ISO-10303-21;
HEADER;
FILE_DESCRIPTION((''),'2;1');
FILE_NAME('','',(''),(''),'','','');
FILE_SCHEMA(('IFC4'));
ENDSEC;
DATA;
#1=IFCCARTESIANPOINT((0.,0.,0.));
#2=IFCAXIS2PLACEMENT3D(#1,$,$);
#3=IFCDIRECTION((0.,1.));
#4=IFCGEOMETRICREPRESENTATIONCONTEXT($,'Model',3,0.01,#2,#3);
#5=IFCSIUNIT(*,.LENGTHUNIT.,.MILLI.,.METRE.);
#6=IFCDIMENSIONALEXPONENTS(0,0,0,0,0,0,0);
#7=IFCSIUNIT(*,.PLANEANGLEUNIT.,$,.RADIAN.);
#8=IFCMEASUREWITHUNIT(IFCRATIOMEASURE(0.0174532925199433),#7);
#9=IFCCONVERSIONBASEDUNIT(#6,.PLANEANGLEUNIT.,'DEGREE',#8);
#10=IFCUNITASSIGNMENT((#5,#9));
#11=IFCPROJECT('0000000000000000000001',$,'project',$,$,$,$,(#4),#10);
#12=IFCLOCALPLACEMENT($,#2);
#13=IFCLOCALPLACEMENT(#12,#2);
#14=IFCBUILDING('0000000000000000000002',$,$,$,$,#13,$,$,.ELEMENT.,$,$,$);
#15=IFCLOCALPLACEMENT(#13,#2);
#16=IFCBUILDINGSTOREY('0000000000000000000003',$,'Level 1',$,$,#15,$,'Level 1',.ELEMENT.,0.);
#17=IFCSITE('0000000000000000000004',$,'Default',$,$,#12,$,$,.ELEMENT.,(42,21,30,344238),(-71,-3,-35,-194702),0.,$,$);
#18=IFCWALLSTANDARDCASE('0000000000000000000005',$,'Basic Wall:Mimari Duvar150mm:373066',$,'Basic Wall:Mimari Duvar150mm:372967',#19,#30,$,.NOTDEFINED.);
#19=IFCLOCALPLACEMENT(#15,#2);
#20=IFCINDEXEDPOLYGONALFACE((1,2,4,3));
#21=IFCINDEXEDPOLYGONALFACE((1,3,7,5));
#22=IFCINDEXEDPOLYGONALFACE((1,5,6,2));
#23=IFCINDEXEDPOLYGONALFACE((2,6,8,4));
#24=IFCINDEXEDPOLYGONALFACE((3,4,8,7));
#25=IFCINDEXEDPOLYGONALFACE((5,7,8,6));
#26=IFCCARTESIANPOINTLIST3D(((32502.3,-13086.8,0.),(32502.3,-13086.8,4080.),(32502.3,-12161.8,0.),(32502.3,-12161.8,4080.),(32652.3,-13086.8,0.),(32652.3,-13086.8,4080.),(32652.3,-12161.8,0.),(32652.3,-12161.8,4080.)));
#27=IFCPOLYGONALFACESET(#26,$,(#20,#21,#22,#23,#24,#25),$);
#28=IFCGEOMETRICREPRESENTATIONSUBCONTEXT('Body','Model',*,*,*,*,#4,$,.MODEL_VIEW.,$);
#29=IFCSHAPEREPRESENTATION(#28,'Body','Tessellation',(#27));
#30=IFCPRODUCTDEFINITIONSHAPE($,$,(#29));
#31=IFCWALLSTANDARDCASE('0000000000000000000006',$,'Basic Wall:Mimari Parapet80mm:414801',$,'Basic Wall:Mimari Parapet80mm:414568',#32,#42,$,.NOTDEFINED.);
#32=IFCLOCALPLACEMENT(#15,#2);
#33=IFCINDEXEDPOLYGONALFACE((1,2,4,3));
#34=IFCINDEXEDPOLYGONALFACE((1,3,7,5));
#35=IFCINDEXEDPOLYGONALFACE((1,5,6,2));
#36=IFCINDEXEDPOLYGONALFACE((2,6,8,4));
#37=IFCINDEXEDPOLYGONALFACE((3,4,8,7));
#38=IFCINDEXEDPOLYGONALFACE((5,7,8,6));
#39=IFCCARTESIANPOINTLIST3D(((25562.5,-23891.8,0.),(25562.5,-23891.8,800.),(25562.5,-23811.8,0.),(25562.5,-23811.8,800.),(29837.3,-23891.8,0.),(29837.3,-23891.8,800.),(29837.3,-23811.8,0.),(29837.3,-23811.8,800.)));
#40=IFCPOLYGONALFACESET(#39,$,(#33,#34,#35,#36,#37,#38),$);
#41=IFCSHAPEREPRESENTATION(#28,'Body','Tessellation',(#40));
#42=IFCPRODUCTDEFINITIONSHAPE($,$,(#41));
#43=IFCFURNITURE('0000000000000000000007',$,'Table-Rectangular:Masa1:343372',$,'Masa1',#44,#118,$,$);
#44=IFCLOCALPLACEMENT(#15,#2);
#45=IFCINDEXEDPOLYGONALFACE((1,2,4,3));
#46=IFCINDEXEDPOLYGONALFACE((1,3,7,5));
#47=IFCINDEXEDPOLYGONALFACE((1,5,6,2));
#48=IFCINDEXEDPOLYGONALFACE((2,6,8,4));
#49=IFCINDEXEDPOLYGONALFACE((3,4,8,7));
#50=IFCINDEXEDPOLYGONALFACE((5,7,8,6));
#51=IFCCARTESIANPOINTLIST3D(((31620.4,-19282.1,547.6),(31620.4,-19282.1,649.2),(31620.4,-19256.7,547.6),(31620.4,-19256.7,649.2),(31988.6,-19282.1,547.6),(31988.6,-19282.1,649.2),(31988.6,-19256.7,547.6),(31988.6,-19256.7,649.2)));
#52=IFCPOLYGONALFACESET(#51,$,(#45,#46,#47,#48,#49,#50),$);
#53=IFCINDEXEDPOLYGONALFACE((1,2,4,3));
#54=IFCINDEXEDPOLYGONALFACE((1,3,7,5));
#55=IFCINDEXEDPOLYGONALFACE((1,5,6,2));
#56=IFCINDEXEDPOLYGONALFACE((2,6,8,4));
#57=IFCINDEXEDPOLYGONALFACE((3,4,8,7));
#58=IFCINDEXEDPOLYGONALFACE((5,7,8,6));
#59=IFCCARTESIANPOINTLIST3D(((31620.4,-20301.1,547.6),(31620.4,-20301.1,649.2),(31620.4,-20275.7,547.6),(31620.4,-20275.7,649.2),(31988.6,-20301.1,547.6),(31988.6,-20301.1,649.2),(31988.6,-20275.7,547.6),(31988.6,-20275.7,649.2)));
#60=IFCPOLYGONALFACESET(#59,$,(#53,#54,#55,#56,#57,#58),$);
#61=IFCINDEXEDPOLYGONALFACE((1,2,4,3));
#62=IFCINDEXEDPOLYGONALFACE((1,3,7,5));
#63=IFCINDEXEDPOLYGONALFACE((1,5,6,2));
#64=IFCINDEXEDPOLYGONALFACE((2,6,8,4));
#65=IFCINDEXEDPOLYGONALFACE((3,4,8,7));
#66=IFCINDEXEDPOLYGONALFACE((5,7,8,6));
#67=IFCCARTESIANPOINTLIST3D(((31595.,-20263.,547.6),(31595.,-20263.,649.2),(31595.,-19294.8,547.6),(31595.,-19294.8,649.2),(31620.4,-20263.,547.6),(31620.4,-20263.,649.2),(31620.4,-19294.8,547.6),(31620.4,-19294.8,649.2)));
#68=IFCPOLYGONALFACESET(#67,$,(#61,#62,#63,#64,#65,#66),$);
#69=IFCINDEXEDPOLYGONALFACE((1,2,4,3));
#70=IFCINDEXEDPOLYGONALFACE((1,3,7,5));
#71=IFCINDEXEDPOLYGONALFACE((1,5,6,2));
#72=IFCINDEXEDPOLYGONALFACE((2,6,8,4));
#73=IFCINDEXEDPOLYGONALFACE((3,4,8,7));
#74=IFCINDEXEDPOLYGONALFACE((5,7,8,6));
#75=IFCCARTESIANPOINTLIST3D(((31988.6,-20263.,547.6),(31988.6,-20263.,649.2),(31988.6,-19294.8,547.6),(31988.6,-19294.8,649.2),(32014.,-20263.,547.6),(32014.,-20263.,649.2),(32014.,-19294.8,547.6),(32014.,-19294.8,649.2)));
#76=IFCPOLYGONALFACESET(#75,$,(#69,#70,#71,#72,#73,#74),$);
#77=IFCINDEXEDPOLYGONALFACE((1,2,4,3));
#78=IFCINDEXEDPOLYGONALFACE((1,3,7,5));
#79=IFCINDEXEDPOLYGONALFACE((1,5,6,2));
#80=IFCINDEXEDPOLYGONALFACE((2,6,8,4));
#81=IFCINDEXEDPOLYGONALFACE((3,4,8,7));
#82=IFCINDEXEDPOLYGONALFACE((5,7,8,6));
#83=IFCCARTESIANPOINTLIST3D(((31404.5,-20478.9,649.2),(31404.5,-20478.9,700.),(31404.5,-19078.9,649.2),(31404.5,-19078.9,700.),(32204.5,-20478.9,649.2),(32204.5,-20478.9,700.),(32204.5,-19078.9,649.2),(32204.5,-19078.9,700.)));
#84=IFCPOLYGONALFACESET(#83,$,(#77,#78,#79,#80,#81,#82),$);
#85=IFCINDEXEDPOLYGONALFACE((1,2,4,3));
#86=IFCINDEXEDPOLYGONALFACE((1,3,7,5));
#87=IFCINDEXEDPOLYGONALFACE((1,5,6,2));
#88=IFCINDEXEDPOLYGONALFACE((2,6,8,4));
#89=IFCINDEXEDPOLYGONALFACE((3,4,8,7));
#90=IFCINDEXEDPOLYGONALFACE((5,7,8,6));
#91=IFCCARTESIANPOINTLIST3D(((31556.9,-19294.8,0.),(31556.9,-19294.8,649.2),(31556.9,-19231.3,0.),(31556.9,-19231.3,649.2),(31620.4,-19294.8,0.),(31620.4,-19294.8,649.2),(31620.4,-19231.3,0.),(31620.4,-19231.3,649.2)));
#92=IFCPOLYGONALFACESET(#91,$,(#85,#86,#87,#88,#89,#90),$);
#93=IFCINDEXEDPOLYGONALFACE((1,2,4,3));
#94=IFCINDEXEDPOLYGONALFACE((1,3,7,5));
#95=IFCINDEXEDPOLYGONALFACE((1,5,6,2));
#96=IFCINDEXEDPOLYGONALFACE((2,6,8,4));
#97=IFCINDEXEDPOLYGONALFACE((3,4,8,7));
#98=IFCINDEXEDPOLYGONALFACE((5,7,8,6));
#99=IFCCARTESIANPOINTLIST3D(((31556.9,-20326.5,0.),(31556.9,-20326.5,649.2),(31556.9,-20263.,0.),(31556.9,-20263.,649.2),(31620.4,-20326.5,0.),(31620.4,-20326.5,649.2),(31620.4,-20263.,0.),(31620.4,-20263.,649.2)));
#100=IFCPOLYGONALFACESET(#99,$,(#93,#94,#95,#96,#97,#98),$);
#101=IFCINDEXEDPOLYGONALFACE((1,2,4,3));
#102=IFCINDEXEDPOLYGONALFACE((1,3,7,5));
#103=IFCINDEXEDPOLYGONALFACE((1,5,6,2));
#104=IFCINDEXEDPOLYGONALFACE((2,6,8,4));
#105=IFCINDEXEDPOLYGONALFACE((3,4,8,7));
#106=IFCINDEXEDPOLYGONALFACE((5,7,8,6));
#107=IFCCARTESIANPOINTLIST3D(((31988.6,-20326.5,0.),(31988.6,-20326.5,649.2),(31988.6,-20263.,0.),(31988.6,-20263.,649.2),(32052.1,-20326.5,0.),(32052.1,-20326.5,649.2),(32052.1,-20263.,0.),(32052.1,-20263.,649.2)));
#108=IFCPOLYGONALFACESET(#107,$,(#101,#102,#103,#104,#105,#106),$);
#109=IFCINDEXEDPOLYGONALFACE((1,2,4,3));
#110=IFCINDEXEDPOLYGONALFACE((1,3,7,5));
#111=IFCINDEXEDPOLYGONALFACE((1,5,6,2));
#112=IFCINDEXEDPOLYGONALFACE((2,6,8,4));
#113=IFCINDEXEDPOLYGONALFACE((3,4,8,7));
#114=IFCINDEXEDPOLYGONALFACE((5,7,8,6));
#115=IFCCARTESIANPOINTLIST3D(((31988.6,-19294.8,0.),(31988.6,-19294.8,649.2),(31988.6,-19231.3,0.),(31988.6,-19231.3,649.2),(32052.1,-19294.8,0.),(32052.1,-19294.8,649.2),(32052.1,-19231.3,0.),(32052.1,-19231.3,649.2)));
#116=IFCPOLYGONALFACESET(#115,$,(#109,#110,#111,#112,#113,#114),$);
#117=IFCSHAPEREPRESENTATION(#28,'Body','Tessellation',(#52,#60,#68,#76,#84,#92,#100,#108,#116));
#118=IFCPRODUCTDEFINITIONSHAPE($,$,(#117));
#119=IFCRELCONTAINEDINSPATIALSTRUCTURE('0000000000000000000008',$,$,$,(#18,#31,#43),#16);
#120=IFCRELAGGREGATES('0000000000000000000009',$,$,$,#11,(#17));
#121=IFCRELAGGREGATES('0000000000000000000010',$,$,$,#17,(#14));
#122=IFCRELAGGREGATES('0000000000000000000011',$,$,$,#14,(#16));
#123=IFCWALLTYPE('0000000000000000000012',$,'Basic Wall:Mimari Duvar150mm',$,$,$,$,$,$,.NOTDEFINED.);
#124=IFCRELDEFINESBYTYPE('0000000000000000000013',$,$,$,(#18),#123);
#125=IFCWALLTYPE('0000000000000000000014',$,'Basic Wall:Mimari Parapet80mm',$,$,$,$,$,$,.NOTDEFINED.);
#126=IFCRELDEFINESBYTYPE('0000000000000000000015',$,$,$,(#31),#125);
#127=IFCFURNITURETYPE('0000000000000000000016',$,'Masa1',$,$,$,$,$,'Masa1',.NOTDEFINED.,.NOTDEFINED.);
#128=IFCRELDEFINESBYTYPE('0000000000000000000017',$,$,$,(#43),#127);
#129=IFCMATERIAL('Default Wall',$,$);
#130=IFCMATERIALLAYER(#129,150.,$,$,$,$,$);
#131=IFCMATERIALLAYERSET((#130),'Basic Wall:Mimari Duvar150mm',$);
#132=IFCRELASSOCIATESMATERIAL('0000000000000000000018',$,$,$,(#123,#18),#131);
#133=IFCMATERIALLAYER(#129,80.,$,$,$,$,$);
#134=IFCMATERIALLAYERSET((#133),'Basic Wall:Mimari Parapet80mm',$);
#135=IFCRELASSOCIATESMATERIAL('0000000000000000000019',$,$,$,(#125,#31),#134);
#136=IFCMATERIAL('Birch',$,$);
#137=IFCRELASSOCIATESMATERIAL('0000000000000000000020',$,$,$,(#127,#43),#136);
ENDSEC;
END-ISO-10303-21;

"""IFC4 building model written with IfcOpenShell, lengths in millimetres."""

from ifc_helpers import new_model, entity, si_unit, converted_unit, direction, frame, frame_2d, origin, origin_2d_with_axis, place, context, subcontext, project, spatial, rectangle, extrude, source, transform, mapped, material, layer, layer_set, layer_usage, type_object, type_shapes, element, save


model = new_model("IFC4")

# Units and contexts
model_context = context("Model", 3, precision=0.01, world=origin(), true_north=direction((0.0, 1.0)))
body_context = subcontext(model_context, "Body", "Model", "MODEL_VIEW")
ifc_project = project(units=[si_unit("LENGTHUNIT", "METRE", prefix="MILLI"), converted_unit("PLANEANGLEUNIT", "DEGREE", entity("IfcRatioMeasure", 0.0174532925199433), si_unit("PLANEANGLEUNIT", "RADIAN"), dimensions=[0, 0, 0, 0, 0, 0, 0])], contexts=[model_context])

# Site, building, storey
site_placement = place(None, origin())
site = spatial("IfcSite", under=ifc_project, at=site_placement, Name="Default", CompositionType="ELEMENT", RefLatitude=(42, 21, 30, 344238), RefLongitude=(-71, -3, -35, -194702), RefElevation=0.0)
building_placement = place(site_placement, origin())
building = spatial("IfcBuilding", under=site, at=building_placement, CompositionType="ELEMENT")
storey_placement = place(building_placement, origin())
storey = spatial("IfcBuildingStorey", under=building, at=storey_placement, Name="Level 1", LongName="Level 1", CompositionType="ELEMENT", Elevation=0.0)

# Walls
ifc_material_1 = material(Name="Default Wall")
ifc_layer_1 = layer(ifc_material_1, 150.0)
ifc_layer_set_1 = layer_set([ifc_layer_1], Name="Basic Wall:Mimari Duvar150mm")
ifc_layer_usage_1 = layer_usage(ifc_layer_set_1, "AXIS2", "NEGATIVE", 75.0)
wall_type_1 = type_object("IfcWallType", Name="Basic Wall:Mimari Duvar150mm", PredefinedType="NOTDEFINED", material=ifc_layer_set_1)
wall_1_placement = place(storey_placement, frame((32577.3, -13086.8, 0.0), z_axis=(0.0, 0.0, 1.0), x_axis=(0.0, 1.0, 0.0)))
element("IfcWallStandardCase", 1, at=wall_1_placement, inside=storey, type_object=wall_type_1, material=ifc_layer_usage_1, Name="Basic Wall:Mimari Duvar150mm:373066", ObjectType="Basic Wall:Mimari Duvar150mm:372967", PredefinedType="NOTDEFINED", context=body_context, shape_type="SweptSolid", body=[
    extrude(rectangle(XDim=925.0, YDim=150.0, at=frame_2d((462.5, 0.0), x_axis=(-1.0, 0.0))), origin(), (0.0, 0.0, 1.0), 4080.0),
])
ifc_layer_2 = layer(ifc_material_1, 80.0)
ifc_layer_set_2 = layer_set([ifc_layer_2], Name="Basic Wall:Mimari Parapet80mm")
ifc_layer_usage_2 = layer_usage(ifc_layer_set_2, "AXIS2", "NEGATIVE", 40.0)
wall_type_2 = type_object("IfcWallType", Name="Basic Wall:Mimari Parapet80mm", PredefinedType="NOTDEFINED", material=ifc_layer_set_2)
wall_2_placement = place(storey_placement, frame((25562.5, -23851.8, 0.0)))
element("IfcWallStandardCase", 2, at=wall_2_placement, inside=storey, type_object=wall_type_2, material=ifc_layer_usage_2, Name="Basic Wall:Mimari Parapet80mm:414801", ObjectType="Basic Wall:Mimari Parapet80mm:414568", PredefinedType="NOTDEFINED", context=body_context, shape_type="SweptSolid", body=[
    extrude(rectangle(XDim=4274.8, YDim=80.0, at=frame_2d((2137.4, 0.0), x_axis=(-1.0, 0.0))), origin(), (0.0, 0.0, 1.0), 800.0),
])

# Furniture
ifc_material_2 = material(Name="Birch")
furniture_type = type_object("IfcFurnitureType", Name="Masa1", ElementType="Masa1", AssemblyPlace="NOTDEFINED", PredefinedType="NOTDEFINED", material=ifc_material_2)
shared_shape_1 = source(origin(), body_context, "Body", "SweptSolid", [
    extrude(rectangle(XDim=25.4, YDim=368.2, at=origin_2d_with_axis()), frame((509.5, 0.0, 547.6)), (0.0, 0.0, 1.0), 101.6),
    extrude(rectangle(XDim=368.2, YDim=25.4, at=origin_2d_with_axis()), frame((-509.5, 0.0, 547.6), z_axis=(0.0, 0.0, 1.0), x_axis=(0.0, 1.0, 0.0)), (0.0, 0.0, 1.0), 101.6),
    extrude(rectangle(XDim=968.2, YDim=25.4, at=frame_2d((0.0, 0.0), x_axis=(1.0, 0.0))), frame((0.0, 196.8, 547.6), z_axis=(0.0, 0.0, 1.0), x_axis=(-1.0, 0.0, 0.0)), (0.0, 0.0, 1.0), 101.6),
    extrude(rectangle(XDim=25.4, YDim=968.2, at=origin_2d_with_axis()), frame((0.0, -196.8, 547.6), z_axis=(0.0, 0.0, 1.0), x_axis=(0.0, 1.0, 0.0)), (0.0, 0.0, 1.0), 101.6),
    extrude(rectangle(XDim=1400.0, YDim=800.0, at=origin_2d_with_axis()), frame((0.0, 0.0, 649.2), z_axis=(0.0, 0.0, 1.0), x_axis=(-1.0, 0.0, 0.0)), (0.0, 0.0, 1.0), 50.8),
    extrude(rectangle(XDim=63.5, YDim=63.5, at=origin_2d_with_axis()), frame((515.9, 215.9, 0.0), z_axis=(0.0, 0.0, 1.0), x_axis=(0.0, -1.0, 0.0)), (0.0, 0.0, 1.0), 649.2),
    extrude(rectangle(XDim=63.5, YDim=63.5, at=origin_2d_with_axis()), frame((-515.9, 215.9, 0.0), z_axis=(0.0, 0.0, 1.0), x_axis=(-1.0, 0.0, 0.0)), (0.0, 0.0, 1.0), 649.2),
    extrude(rectangle(XDim=63.5, YDim=63.5, at=origin_2d_with_axis()), frame((-515.9, -215.9, 0.0), z_axis=(0.0, 0.0, 1.0), x_axis=(0.0, 1.0, 0.0)), (0.0, 0.0, 1.0), 649.2),
    extrude(rectangle(XDim=63.5, YDim=63.5, at=frame_2d((0.0, 0.0), x_axis=(1.0, 0.0))), frame((515.9, -215.9, 0.0)), (0.0, 0.0, 1.0), 649.2),
])
type_shapes(furniture_type, [shared_shape_1])
furniture_placement = place(storey_placement, frame((31804.5, -19778.9, 0.0), z_axis=(0.0, 0.0, 1.0), x_axis=(0.0, 1.0, 0.0)))
element("IfcFurniture", 3, at=furniture_placement, inside=storey, type_object=furniture_type, material=ifc_material_2, Name="Table-Rectangular:Masa1:343372", ObjectType="Masa1", context=body_context, shape_type="MappedRepresentation", body=[
    mapped(shared_shape_1, transform((0.0, 0.0, 0.0), scale=1.0)),
])

save(model, "model.ifc")
